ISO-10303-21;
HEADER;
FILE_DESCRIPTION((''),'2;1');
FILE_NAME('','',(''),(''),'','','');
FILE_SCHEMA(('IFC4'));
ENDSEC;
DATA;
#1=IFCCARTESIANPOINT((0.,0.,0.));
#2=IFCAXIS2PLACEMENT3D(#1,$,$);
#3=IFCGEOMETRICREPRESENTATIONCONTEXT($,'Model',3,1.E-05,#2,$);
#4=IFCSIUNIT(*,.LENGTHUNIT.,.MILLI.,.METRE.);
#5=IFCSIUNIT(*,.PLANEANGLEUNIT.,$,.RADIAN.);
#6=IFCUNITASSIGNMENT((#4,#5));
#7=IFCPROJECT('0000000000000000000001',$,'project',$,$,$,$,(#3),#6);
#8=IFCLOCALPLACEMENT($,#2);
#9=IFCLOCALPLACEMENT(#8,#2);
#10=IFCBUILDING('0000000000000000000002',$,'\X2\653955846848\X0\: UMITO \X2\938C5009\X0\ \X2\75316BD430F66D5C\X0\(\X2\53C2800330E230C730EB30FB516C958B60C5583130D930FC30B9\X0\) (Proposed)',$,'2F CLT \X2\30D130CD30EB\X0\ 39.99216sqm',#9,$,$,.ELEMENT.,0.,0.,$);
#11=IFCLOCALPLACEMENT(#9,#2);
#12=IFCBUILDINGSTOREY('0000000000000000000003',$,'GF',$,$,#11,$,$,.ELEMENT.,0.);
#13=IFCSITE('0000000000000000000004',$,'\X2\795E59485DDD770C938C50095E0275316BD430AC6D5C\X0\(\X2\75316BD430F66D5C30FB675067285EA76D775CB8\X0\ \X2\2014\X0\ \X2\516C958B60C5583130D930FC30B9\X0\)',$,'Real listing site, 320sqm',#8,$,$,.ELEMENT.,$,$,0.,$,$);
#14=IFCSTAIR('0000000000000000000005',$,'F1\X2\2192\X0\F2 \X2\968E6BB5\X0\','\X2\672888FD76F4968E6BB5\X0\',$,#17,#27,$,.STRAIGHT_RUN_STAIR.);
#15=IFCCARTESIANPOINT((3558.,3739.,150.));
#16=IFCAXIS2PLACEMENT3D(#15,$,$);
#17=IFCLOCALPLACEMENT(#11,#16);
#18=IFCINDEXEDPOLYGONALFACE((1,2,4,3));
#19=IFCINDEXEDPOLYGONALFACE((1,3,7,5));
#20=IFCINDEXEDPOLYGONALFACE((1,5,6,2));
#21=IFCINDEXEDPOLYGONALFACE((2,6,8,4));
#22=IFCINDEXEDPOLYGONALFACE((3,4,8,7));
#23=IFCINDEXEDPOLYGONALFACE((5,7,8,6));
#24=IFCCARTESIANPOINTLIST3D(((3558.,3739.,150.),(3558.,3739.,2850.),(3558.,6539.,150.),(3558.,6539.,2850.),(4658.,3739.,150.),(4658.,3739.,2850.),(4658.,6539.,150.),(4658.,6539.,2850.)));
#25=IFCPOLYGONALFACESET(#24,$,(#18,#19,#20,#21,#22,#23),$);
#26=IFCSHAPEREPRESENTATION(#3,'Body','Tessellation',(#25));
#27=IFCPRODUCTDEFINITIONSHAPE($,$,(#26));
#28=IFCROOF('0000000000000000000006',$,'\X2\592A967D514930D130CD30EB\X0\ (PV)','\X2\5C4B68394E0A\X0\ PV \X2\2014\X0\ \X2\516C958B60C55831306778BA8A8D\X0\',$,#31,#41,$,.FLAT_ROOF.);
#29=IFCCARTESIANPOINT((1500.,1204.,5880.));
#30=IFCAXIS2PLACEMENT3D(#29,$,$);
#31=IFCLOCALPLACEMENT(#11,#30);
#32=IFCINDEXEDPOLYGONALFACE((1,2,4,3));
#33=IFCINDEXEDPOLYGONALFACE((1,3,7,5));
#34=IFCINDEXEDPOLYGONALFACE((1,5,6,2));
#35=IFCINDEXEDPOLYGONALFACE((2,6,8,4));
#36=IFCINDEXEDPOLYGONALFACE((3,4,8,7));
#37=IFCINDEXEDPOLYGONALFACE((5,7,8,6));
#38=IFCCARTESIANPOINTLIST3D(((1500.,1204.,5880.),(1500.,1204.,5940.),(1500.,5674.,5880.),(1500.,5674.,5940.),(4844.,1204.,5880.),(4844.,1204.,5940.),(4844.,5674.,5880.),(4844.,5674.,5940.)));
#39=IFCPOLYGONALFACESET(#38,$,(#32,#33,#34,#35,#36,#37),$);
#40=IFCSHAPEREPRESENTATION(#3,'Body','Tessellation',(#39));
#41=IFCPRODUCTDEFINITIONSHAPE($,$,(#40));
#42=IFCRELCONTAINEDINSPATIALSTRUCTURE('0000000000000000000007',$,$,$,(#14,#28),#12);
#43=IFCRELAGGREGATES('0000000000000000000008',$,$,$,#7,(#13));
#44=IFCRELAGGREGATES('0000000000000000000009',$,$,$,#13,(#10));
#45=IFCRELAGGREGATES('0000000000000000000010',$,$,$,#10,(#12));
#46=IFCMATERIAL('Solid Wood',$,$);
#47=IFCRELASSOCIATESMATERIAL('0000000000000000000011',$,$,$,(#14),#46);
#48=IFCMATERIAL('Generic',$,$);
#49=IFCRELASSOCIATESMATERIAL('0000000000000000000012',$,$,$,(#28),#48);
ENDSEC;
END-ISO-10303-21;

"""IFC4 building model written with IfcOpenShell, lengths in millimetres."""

from ifc_helpers import new_model, si_unit, frame, frame_2d, origin, place, context, project, spatial, rectangle, extrude, material, element, save


model = new_model("IFC4")

# Units and contexts
model_context = context("Model", 3, precision=1e-05, world=origin())
ifc_project = project(units=[si_unit("LENGTHUNIT", "METRE", prefix="MILLI"), si_unit("PLANEANGLEUNIT", "RADIAN")], contexts=[model_context])

# Site, building, storey
site_placement = place(None, origin())
site = spatial("IfcSite", under=ifc_project, at=site_placement, Name="神奈川県鎌倉市由比ガ浜(由比ヶ浜・材木座海岸 — 公開情報ベース)", ObjectType="Real listing site, 320sqm", CompositionType="ELEMENT", RefElevation=0.0)
building_placement = place(site_placement, origin())
building = spatial("IfcBuilding", under=site, at=building_placement, Name="改善案: UMITO 鎌倉 由比ヶ浜(参考モデル・公開情報ベース) (Proposed)", ObjectType="2F CLT パネル 39.99216sqm", CompositionType="ELEMENT", ElevationOfRefHeight=0.0, ElevationOfTerrain=0.0)
storey_placement = place(building_placement, origin())
storey = spatial("IfcBuildingStorey", under=building, at=storey_placement, Name="GF", CompositionType="ELEMENT", Elevation=0.0)

# Shared definitions
ifc_material_1 = material(Name="Generic")

# Stair
ifc_material_2 = material(Name="Solid Wood")
stair_placement = place(storey_placement, frame((3558.0, 3739.0, 150.0)))
element("IfcStair", 1, at=stair_placement, inside=storey, material=ifc_material_2, Name="F1→F2 階段", Description="木製直階段", PredefinedType="STRAIGHT_RUN_STAIR", context=model_context, shape_type="SweptSolid", body=[
    extrude(rectangle(XDim=1100.0, YDim=2800.0, at=frame_2d((550.0, 1400.0))), frame((3558.0, 3739.0, 150.0)), (0.0, 0.0, 1.0), 2700.0),
])

# Roof
roof_placement = place(storey_placement, frame((1500.0, 1204.0, 5880.0)))
element("IfcRoof", 2, at=roof_placement, inside=storey, material=ifc_material_1, Name="太陽光パネル (PV)", Description="屋根上 PV — 公開情報で確認", PredefinedType="FLAT_ROOF", context=model_context, shape_type="SweptSolid", body=[
    extrude(rectangle(XDim=3344.0, YDim=4470.0, at=frame_2d((1672.0, 2235.0))), frame((1500.0, 1204.0, 5880.0)), (0.0, 0.0, 1.0), 60.0),
])

save(model, "model.ifc")
